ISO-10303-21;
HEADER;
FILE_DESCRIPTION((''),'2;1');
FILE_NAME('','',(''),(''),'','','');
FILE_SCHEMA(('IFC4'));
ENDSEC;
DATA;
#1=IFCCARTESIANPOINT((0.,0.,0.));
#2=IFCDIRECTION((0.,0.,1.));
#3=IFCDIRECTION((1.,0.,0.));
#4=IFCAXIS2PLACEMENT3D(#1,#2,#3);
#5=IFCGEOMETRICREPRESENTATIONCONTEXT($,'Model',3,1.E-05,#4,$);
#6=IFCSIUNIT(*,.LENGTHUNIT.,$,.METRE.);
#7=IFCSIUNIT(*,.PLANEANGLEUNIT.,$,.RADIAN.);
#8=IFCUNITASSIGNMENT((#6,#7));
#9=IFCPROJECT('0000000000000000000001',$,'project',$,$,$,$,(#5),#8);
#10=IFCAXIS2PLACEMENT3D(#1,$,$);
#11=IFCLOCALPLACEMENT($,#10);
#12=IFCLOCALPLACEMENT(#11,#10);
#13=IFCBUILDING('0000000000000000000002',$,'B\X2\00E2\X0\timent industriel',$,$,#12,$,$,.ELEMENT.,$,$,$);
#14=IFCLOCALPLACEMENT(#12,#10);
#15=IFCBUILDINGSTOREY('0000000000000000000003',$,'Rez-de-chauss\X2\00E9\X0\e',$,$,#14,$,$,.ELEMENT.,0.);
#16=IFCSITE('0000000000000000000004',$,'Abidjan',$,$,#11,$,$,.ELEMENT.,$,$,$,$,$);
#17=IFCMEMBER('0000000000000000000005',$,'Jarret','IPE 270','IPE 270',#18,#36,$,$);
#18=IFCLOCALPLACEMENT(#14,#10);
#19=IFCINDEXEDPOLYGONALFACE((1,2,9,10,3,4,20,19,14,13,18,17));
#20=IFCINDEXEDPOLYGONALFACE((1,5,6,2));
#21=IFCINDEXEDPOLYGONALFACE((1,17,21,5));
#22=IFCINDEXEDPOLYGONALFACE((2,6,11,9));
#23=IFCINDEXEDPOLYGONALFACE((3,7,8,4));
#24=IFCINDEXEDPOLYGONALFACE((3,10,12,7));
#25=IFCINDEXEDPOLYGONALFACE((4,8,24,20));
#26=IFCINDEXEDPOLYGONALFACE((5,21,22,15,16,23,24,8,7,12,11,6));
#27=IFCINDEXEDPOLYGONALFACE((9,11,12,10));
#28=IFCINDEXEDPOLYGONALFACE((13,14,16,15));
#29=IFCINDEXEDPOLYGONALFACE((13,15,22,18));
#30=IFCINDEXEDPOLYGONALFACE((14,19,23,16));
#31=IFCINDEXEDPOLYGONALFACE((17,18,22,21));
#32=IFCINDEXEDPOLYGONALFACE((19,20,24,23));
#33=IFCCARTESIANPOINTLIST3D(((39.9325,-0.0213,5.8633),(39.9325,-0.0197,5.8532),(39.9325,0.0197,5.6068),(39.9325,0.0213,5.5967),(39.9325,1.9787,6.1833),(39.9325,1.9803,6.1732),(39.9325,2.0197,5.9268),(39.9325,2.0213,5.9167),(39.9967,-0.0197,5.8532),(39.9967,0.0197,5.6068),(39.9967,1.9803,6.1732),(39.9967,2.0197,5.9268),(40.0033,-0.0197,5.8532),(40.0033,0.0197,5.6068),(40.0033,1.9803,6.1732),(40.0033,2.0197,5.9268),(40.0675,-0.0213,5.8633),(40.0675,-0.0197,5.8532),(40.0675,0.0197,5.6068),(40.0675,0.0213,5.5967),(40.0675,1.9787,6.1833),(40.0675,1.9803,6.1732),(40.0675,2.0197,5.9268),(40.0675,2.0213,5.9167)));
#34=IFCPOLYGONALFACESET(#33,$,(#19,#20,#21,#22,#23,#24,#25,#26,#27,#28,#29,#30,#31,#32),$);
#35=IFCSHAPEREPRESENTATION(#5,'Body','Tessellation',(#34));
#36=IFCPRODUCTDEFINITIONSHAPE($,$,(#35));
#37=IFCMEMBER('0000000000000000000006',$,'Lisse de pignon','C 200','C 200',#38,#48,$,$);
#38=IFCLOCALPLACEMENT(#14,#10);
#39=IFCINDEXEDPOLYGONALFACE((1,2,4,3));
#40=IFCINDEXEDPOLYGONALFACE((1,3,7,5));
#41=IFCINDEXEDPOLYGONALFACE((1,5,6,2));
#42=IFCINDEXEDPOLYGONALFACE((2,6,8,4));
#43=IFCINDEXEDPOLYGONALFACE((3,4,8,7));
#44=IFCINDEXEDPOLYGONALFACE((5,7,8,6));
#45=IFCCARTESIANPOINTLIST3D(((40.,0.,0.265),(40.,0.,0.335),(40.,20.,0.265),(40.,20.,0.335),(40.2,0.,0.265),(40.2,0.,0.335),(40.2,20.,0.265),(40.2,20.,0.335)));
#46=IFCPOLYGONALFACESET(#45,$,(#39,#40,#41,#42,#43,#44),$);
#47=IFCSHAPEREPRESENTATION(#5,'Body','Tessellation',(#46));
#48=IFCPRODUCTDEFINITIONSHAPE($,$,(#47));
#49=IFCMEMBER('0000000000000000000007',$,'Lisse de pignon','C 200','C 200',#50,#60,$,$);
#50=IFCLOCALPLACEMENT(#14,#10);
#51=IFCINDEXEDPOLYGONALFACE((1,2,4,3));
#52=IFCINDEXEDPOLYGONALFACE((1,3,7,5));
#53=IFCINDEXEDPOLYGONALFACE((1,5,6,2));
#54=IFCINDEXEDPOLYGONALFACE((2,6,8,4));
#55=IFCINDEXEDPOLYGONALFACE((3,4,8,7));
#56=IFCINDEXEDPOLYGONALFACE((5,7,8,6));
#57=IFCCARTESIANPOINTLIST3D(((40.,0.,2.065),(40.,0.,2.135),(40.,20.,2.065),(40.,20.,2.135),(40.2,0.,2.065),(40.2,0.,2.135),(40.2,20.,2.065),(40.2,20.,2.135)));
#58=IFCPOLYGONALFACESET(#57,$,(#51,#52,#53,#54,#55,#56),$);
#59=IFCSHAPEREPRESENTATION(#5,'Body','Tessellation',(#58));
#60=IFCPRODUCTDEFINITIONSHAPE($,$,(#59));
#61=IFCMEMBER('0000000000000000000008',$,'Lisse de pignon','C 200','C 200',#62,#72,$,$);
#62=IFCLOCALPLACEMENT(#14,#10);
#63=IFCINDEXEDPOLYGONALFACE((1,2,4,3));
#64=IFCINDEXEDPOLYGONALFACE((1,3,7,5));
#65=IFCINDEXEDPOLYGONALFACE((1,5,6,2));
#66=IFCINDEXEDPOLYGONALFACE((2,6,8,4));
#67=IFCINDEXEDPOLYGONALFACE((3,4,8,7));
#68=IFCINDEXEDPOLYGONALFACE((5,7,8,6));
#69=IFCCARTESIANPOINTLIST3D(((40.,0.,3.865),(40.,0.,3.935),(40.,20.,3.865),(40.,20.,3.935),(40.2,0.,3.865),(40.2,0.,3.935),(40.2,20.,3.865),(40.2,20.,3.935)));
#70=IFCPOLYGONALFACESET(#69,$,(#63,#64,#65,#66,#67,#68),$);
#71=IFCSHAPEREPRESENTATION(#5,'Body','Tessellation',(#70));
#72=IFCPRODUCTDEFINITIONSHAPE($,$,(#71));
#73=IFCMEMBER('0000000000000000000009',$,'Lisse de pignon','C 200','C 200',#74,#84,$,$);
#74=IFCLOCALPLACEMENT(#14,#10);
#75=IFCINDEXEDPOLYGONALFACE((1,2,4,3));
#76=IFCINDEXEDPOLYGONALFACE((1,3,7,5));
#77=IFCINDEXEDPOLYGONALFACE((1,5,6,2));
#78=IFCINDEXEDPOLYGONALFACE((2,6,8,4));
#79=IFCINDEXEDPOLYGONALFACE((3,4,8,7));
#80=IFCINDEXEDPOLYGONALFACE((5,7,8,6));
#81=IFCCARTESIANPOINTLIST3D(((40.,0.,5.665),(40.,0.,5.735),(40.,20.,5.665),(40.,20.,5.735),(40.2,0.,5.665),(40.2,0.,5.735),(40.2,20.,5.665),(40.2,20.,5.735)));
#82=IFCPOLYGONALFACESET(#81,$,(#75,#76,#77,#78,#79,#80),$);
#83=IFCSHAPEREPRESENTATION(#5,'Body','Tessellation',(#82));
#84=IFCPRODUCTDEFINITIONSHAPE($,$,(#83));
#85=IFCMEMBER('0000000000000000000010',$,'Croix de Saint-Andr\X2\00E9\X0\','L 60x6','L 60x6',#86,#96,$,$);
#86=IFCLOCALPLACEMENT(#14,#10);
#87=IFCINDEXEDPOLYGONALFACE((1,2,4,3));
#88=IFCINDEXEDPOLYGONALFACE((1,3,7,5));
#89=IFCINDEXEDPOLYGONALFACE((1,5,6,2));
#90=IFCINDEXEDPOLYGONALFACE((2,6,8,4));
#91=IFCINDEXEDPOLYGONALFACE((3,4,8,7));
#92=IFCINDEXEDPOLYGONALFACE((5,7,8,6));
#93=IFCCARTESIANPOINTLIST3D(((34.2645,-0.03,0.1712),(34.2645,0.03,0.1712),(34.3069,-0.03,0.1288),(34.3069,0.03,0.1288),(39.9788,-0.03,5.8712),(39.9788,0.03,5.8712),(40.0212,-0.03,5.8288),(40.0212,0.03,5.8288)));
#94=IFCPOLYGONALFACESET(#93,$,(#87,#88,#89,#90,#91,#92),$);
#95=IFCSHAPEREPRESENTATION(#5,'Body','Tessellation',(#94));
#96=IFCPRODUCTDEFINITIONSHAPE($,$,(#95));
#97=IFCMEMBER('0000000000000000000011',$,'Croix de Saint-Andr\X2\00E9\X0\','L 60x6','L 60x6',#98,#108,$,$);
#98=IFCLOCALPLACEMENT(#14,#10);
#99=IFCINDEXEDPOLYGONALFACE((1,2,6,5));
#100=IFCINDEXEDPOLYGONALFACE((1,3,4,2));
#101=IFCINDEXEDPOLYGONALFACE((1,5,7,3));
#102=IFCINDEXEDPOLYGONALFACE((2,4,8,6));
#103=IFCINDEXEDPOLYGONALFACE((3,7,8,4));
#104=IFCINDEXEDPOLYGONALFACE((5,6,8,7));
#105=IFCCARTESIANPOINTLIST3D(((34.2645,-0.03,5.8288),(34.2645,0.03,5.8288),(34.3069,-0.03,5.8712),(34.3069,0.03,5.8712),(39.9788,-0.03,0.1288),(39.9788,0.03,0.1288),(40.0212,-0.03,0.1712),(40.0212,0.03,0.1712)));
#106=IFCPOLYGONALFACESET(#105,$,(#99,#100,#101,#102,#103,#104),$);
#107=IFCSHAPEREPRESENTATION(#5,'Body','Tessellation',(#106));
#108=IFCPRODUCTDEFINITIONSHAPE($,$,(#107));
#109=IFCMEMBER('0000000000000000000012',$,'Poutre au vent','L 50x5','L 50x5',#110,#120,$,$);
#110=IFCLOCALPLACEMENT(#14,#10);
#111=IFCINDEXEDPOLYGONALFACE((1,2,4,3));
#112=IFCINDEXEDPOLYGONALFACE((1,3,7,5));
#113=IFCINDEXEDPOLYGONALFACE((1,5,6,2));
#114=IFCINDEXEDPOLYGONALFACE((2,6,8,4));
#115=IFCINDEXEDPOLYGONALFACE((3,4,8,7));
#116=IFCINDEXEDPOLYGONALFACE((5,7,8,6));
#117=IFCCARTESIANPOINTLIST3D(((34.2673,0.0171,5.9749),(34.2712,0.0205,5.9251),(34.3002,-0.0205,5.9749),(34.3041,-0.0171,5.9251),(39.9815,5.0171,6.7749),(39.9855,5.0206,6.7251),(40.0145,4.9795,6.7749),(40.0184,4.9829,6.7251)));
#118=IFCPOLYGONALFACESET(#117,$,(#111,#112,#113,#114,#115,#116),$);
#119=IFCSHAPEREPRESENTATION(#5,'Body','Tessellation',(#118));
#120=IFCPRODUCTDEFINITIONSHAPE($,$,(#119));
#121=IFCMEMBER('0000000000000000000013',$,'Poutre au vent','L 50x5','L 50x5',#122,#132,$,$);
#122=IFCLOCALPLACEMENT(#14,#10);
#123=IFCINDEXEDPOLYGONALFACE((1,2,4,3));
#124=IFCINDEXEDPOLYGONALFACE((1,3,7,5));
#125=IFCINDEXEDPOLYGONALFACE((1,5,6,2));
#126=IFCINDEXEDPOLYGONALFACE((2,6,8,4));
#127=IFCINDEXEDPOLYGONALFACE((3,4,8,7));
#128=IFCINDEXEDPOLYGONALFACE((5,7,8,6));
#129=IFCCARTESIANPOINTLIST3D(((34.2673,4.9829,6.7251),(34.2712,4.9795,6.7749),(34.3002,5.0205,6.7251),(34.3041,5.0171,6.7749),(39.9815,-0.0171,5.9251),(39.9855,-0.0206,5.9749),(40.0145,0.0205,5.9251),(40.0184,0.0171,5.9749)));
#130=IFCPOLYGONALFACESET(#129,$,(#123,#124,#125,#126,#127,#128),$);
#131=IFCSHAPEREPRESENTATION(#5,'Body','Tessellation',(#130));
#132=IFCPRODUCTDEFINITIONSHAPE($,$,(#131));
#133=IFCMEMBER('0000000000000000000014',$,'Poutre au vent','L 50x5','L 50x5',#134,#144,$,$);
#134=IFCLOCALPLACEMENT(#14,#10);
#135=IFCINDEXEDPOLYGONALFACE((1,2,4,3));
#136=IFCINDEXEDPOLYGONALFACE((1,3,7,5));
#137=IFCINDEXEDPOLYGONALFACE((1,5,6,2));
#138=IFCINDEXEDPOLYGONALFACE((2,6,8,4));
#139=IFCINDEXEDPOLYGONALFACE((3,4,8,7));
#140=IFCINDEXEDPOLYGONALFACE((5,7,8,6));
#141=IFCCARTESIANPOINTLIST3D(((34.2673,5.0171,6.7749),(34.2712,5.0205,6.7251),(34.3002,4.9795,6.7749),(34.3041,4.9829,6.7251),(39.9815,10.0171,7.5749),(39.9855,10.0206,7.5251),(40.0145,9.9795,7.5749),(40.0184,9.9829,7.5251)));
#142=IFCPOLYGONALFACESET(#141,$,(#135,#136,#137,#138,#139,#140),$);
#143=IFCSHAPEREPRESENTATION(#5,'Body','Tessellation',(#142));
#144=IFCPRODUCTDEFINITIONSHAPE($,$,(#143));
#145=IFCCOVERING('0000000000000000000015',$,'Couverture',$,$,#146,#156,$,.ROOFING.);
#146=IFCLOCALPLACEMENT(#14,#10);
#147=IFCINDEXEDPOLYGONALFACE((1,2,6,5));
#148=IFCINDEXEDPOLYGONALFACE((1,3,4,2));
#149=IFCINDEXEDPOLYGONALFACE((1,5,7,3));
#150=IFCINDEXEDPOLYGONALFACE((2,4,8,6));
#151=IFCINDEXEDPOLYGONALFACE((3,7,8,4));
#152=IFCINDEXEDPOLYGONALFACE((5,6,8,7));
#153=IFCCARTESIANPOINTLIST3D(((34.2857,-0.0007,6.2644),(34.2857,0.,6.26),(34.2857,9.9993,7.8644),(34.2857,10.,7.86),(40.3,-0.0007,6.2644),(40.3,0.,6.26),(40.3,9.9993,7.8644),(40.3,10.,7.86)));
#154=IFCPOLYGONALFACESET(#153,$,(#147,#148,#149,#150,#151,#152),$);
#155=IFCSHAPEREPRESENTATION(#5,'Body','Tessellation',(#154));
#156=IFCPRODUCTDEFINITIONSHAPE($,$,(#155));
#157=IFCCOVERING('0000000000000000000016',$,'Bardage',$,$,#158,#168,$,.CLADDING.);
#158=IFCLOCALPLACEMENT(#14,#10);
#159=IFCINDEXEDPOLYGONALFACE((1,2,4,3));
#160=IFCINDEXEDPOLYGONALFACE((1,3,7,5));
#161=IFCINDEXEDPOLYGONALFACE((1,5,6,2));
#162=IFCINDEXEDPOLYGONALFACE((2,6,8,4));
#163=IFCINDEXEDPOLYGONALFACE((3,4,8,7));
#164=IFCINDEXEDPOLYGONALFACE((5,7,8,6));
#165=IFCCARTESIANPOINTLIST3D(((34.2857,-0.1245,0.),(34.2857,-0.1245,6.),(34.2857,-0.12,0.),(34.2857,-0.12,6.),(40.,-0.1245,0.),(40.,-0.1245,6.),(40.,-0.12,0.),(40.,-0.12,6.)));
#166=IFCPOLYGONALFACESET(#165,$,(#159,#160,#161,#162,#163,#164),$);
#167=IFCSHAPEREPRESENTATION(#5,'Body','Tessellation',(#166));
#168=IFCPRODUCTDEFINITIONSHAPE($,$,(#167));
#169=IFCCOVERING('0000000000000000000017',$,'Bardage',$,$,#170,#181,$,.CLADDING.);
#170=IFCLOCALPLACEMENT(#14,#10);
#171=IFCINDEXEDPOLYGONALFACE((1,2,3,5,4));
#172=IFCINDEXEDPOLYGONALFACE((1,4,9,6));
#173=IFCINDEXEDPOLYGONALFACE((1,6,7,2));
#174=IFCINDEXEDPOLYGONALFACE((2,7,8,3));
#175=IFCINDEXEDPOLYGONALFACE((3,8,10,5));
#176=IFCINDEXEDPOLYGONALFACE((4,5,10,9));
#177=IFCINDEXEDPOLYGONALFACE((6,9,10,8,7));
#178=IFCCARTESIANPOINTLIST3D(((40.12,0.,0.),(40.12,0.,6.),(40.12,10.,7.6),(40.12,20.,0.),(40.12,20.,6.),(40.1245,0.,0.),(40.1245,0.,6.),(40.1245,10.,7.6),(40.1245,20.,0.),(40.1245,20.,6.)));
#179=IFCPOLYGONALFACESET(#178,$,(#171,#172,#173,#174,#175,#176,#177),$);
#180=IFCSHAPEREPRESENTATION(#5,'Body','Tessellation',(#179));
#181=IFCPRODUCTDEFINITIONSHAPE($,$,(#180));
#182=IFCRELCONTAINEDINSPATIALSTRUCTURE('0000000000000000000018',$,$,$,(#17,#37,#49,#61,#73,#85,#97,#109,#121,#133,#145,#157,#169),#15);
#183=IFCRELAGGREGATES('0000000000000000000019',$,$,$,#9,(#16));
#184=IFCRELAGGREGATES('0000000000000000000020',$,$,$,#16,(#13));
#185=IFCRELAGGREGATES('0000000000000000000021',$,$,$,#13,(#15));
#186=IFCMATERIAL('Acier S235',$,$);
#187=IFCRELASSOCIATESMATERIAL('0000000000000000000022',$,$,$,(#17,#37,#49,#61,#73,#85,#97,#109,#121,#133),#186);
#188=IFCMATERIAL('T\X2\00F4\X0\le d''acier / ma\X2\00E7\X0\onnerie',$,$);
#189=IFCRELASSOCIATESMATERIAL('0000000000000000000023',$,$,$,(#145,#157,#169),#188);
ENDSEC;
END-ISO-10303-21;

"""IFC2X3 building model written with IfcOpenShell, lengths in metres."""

from ifc_helpers import new_model, si_unit, frame, origin, origin_with_axes, origin_2d, place, context, project, spatial, polyline, rectangle, i_section, outline, extrude, material, element, save


model = new_model("IFC2X3")

# Units and contexts
model_context = context("Model", 3, precision=1e-05, world=origin_with_axes())
ifc_project = project(units=[si_unit("LENGTHUNIT", "METRE"), si_unit("PLANEANGLEUNIT", "RADIAN")], contexts=[model_context])

# Site, building, storey
site_placement = place(None, origin())
site = spatial("IfcSite", under=ifc_project, at=site_placement, Name="Abidjan", CompositionType="ELEMENT")
building_placement = place(site_placement, origin())
building = spatial("IfcBuilding", under=site, at=building_placement, Name="Bâtiment industriel", CompositionType="ELEMENT")
storey_placement = place(building_placement, origin())
storey = spatial("IfcBuildingStorey", under=building, at=storey_placement, Name="Rez-de-chaussée", CompositionType="ELEMENT", Elevation=0.0)

# Shared definitions
ifc_material_1 = material(Name="Acier S235")

# Members
member_1_placement = place(storey_placement, frame((40.0, 0.0, 5.73), z_axis=(0.0, 0.98744, 0.15799), x_axis=(1.0, 0.0, 0.0)))
element("IfcMember", 1, at=member_1_placement, inside=storey, material=ifc_material_1, Name="Jarret", Description="IPE 270", ObjectType="IPE 270", context=model_context, shape_type="SweptSolid", body=[
    extrude(i_section(OverallWidth=0.135, OverallDepth=0.27, WebThickness=0.0066, FlangeThickness=0.0102, at=origin_2d()), origin(), (0.0, 0.0, 1.0), 2.0254),
])
for number, where, z_axis, x_axis, name in (
    (2, (40.1, 0.0, 0.3), (0.0, 1.0, 0.0), (0.0, 0.0, 1.0), "Lisse de pignon"),
    (3, (40.1, 0.0, 2.1), (0.0, 1.0, 0.0), (0.0, 0.0, 1.0), "Lisse de pignon"),
    (4, (40.1, 0.0, 3.9), (0.0, 1.0, 0.0), (0.0, 0.0, 1.0), "Lisse de pignon"),
    (5, (40.1, 0.0, 5.7), (0.0, 1.0, 0.0), (0.0, 0.0, 1.0), "Lisse de pignon"),
):
    element("IfcMember", number, at=place(storey_placement, frame(where, z_axis=z_axis, x_axis=x_axis)), inside=storey, material=ifc_material_1, Name=name, Description="C 200", ObjectType="C 200", context=model_context, shape_type="SweptSolid", body=[
        extrude(rectangle(XDim=0.07, YDim=0.2, at=origin_2d()), origin(), (0.0, 0.0, 1.0), 20.0),
    ])
for number, where, z_axis, x_axis, name in (
    (6, (34.2857, 0.0, 0.15), (0.70799, 0.0, 0.70622), (0.0, 1.0, 0.0), "Croix de Saint-André"),
    (7, (40.0, 0.0, 0.15), (-0.70799, 0.0, 0.70622), (0.0, 1.0, 0.0), "Croix de Saint-André"),
):
    element("IfcMember", number, at=place(storey_placement, frame(where, z_axis=z_axis, x_axis=x_axis)), inside=storey, material=ifc_material_1, Name=name, Description="L 60x6", ObjectType="L 60x6", context=model_context, shape_type="SweptSolid", body=[
        extrude(rectangle(XDim=0.06, YDim=0.06, at=origin_2d()), origin(), (0.0, 0.0, 1.0), 8.0711),
    ])
for number, where, z_axis, x_axis, name in (
    (8, (34.2857, 0.0, 5.95), (0.74843, 0.65488, 0.10478), (-0.07886, -0.069, 0.9945), "Poutre au vent"),
    (9, (34.2857, 5.0, 6.75), (0.74843, -0.65488, -0.10478), (0.07886, -0.069, 0.9945), "Poutre au vent"),
    (10, (34.2857, 5.0, 6.75), (0.74843, 0.65488, 0.10478), (-0.07886, -0.069, 0.9945), "Poutre au vent"),
):
    element("IfcMember", number, at=place(storey_placement, frame(where, z_axis=z_axis, x_axis=x_axis)), inside=storey, material=ifc_material_1, Name=name, Description="L 50x5", ObjectType="L 50x5", context=model_context, shape_type="SweptSolid", body=[
        extrude(rectangle(XDim=0.05, YDim=0.05, at=origin_2d()), origin(), (0.0, 0.0, 1.0), 7.635),
    ])

# Coverings
ifc_material_2 = material(Name="Tôle d'acier / maçonnerie")
covering_1_placement = place(storey_placement, frame((34.2857, 0.0, 6.26), z_axis=(0.0, -0.15799, 0.98744), x_axis=(1.0, 0.0, 0.0)))
element("IfcCovering", 11, at=covering_1_placement, inside=storey, material=ifc_material_2, Name="Couverture", PredefinedType="ROOFING", context=model_context, shape_type="SweptSolid", body=[
    extrude(outline(polyline([(0.0, 0.0), (6.0143, 0.0), (6.0143, 10.1272), (0.0, 10.1272), (0.0, 0.0)])), origin(), (0.0, 0.0, 1.0), 0.0045),
])
covering_2_placement = place(storey_placement, frame((34.2857, -0.12, 0.0), z_axis=(0.0, -1.0, 0.0), x_axis=(1.0, 0.0, 0.0)))
element("IfcCovering", 12, at=covering_2_placement, inside=storey, material=ifc_material_2, Name="Bardage", PredefinedType="CLADDING", context=model_context, shape_type="SweptSolid", body=[
    extrude(outline(polyline([(0.0, 0.0), (5.7143, 0.0), (5.7143, 6.0), (0.0, 6.0), (0.0, 0.0)])), origin(), (0.0, 0.0, 1.0), 0.0045),
])
covering_3_placement = place(storey_placement, frame((40.12, 0.0, 0.0), z_axis=(1.0, 0.0, 0.0), x_axis=(0.0, 1.0, 0.0)))
element("IfcCovering", 13, at=covering_3_placement, inside=storey, material=ifc_material_2, Name="Bardage", PredefinedType="CLADDING", context=model_context, shape_type="SweptSolid", body=[
    extrude(outline(polyline([(0.0, 0.0), (20.0, 0.0), (20.0, 6.0), (10.0, 7.6), (0.0, 6.0), (0.0, 0.0)])), origin(), (0.0, 0.0, 1.0), 0.0045),
])

save(model, "model.ifc")
